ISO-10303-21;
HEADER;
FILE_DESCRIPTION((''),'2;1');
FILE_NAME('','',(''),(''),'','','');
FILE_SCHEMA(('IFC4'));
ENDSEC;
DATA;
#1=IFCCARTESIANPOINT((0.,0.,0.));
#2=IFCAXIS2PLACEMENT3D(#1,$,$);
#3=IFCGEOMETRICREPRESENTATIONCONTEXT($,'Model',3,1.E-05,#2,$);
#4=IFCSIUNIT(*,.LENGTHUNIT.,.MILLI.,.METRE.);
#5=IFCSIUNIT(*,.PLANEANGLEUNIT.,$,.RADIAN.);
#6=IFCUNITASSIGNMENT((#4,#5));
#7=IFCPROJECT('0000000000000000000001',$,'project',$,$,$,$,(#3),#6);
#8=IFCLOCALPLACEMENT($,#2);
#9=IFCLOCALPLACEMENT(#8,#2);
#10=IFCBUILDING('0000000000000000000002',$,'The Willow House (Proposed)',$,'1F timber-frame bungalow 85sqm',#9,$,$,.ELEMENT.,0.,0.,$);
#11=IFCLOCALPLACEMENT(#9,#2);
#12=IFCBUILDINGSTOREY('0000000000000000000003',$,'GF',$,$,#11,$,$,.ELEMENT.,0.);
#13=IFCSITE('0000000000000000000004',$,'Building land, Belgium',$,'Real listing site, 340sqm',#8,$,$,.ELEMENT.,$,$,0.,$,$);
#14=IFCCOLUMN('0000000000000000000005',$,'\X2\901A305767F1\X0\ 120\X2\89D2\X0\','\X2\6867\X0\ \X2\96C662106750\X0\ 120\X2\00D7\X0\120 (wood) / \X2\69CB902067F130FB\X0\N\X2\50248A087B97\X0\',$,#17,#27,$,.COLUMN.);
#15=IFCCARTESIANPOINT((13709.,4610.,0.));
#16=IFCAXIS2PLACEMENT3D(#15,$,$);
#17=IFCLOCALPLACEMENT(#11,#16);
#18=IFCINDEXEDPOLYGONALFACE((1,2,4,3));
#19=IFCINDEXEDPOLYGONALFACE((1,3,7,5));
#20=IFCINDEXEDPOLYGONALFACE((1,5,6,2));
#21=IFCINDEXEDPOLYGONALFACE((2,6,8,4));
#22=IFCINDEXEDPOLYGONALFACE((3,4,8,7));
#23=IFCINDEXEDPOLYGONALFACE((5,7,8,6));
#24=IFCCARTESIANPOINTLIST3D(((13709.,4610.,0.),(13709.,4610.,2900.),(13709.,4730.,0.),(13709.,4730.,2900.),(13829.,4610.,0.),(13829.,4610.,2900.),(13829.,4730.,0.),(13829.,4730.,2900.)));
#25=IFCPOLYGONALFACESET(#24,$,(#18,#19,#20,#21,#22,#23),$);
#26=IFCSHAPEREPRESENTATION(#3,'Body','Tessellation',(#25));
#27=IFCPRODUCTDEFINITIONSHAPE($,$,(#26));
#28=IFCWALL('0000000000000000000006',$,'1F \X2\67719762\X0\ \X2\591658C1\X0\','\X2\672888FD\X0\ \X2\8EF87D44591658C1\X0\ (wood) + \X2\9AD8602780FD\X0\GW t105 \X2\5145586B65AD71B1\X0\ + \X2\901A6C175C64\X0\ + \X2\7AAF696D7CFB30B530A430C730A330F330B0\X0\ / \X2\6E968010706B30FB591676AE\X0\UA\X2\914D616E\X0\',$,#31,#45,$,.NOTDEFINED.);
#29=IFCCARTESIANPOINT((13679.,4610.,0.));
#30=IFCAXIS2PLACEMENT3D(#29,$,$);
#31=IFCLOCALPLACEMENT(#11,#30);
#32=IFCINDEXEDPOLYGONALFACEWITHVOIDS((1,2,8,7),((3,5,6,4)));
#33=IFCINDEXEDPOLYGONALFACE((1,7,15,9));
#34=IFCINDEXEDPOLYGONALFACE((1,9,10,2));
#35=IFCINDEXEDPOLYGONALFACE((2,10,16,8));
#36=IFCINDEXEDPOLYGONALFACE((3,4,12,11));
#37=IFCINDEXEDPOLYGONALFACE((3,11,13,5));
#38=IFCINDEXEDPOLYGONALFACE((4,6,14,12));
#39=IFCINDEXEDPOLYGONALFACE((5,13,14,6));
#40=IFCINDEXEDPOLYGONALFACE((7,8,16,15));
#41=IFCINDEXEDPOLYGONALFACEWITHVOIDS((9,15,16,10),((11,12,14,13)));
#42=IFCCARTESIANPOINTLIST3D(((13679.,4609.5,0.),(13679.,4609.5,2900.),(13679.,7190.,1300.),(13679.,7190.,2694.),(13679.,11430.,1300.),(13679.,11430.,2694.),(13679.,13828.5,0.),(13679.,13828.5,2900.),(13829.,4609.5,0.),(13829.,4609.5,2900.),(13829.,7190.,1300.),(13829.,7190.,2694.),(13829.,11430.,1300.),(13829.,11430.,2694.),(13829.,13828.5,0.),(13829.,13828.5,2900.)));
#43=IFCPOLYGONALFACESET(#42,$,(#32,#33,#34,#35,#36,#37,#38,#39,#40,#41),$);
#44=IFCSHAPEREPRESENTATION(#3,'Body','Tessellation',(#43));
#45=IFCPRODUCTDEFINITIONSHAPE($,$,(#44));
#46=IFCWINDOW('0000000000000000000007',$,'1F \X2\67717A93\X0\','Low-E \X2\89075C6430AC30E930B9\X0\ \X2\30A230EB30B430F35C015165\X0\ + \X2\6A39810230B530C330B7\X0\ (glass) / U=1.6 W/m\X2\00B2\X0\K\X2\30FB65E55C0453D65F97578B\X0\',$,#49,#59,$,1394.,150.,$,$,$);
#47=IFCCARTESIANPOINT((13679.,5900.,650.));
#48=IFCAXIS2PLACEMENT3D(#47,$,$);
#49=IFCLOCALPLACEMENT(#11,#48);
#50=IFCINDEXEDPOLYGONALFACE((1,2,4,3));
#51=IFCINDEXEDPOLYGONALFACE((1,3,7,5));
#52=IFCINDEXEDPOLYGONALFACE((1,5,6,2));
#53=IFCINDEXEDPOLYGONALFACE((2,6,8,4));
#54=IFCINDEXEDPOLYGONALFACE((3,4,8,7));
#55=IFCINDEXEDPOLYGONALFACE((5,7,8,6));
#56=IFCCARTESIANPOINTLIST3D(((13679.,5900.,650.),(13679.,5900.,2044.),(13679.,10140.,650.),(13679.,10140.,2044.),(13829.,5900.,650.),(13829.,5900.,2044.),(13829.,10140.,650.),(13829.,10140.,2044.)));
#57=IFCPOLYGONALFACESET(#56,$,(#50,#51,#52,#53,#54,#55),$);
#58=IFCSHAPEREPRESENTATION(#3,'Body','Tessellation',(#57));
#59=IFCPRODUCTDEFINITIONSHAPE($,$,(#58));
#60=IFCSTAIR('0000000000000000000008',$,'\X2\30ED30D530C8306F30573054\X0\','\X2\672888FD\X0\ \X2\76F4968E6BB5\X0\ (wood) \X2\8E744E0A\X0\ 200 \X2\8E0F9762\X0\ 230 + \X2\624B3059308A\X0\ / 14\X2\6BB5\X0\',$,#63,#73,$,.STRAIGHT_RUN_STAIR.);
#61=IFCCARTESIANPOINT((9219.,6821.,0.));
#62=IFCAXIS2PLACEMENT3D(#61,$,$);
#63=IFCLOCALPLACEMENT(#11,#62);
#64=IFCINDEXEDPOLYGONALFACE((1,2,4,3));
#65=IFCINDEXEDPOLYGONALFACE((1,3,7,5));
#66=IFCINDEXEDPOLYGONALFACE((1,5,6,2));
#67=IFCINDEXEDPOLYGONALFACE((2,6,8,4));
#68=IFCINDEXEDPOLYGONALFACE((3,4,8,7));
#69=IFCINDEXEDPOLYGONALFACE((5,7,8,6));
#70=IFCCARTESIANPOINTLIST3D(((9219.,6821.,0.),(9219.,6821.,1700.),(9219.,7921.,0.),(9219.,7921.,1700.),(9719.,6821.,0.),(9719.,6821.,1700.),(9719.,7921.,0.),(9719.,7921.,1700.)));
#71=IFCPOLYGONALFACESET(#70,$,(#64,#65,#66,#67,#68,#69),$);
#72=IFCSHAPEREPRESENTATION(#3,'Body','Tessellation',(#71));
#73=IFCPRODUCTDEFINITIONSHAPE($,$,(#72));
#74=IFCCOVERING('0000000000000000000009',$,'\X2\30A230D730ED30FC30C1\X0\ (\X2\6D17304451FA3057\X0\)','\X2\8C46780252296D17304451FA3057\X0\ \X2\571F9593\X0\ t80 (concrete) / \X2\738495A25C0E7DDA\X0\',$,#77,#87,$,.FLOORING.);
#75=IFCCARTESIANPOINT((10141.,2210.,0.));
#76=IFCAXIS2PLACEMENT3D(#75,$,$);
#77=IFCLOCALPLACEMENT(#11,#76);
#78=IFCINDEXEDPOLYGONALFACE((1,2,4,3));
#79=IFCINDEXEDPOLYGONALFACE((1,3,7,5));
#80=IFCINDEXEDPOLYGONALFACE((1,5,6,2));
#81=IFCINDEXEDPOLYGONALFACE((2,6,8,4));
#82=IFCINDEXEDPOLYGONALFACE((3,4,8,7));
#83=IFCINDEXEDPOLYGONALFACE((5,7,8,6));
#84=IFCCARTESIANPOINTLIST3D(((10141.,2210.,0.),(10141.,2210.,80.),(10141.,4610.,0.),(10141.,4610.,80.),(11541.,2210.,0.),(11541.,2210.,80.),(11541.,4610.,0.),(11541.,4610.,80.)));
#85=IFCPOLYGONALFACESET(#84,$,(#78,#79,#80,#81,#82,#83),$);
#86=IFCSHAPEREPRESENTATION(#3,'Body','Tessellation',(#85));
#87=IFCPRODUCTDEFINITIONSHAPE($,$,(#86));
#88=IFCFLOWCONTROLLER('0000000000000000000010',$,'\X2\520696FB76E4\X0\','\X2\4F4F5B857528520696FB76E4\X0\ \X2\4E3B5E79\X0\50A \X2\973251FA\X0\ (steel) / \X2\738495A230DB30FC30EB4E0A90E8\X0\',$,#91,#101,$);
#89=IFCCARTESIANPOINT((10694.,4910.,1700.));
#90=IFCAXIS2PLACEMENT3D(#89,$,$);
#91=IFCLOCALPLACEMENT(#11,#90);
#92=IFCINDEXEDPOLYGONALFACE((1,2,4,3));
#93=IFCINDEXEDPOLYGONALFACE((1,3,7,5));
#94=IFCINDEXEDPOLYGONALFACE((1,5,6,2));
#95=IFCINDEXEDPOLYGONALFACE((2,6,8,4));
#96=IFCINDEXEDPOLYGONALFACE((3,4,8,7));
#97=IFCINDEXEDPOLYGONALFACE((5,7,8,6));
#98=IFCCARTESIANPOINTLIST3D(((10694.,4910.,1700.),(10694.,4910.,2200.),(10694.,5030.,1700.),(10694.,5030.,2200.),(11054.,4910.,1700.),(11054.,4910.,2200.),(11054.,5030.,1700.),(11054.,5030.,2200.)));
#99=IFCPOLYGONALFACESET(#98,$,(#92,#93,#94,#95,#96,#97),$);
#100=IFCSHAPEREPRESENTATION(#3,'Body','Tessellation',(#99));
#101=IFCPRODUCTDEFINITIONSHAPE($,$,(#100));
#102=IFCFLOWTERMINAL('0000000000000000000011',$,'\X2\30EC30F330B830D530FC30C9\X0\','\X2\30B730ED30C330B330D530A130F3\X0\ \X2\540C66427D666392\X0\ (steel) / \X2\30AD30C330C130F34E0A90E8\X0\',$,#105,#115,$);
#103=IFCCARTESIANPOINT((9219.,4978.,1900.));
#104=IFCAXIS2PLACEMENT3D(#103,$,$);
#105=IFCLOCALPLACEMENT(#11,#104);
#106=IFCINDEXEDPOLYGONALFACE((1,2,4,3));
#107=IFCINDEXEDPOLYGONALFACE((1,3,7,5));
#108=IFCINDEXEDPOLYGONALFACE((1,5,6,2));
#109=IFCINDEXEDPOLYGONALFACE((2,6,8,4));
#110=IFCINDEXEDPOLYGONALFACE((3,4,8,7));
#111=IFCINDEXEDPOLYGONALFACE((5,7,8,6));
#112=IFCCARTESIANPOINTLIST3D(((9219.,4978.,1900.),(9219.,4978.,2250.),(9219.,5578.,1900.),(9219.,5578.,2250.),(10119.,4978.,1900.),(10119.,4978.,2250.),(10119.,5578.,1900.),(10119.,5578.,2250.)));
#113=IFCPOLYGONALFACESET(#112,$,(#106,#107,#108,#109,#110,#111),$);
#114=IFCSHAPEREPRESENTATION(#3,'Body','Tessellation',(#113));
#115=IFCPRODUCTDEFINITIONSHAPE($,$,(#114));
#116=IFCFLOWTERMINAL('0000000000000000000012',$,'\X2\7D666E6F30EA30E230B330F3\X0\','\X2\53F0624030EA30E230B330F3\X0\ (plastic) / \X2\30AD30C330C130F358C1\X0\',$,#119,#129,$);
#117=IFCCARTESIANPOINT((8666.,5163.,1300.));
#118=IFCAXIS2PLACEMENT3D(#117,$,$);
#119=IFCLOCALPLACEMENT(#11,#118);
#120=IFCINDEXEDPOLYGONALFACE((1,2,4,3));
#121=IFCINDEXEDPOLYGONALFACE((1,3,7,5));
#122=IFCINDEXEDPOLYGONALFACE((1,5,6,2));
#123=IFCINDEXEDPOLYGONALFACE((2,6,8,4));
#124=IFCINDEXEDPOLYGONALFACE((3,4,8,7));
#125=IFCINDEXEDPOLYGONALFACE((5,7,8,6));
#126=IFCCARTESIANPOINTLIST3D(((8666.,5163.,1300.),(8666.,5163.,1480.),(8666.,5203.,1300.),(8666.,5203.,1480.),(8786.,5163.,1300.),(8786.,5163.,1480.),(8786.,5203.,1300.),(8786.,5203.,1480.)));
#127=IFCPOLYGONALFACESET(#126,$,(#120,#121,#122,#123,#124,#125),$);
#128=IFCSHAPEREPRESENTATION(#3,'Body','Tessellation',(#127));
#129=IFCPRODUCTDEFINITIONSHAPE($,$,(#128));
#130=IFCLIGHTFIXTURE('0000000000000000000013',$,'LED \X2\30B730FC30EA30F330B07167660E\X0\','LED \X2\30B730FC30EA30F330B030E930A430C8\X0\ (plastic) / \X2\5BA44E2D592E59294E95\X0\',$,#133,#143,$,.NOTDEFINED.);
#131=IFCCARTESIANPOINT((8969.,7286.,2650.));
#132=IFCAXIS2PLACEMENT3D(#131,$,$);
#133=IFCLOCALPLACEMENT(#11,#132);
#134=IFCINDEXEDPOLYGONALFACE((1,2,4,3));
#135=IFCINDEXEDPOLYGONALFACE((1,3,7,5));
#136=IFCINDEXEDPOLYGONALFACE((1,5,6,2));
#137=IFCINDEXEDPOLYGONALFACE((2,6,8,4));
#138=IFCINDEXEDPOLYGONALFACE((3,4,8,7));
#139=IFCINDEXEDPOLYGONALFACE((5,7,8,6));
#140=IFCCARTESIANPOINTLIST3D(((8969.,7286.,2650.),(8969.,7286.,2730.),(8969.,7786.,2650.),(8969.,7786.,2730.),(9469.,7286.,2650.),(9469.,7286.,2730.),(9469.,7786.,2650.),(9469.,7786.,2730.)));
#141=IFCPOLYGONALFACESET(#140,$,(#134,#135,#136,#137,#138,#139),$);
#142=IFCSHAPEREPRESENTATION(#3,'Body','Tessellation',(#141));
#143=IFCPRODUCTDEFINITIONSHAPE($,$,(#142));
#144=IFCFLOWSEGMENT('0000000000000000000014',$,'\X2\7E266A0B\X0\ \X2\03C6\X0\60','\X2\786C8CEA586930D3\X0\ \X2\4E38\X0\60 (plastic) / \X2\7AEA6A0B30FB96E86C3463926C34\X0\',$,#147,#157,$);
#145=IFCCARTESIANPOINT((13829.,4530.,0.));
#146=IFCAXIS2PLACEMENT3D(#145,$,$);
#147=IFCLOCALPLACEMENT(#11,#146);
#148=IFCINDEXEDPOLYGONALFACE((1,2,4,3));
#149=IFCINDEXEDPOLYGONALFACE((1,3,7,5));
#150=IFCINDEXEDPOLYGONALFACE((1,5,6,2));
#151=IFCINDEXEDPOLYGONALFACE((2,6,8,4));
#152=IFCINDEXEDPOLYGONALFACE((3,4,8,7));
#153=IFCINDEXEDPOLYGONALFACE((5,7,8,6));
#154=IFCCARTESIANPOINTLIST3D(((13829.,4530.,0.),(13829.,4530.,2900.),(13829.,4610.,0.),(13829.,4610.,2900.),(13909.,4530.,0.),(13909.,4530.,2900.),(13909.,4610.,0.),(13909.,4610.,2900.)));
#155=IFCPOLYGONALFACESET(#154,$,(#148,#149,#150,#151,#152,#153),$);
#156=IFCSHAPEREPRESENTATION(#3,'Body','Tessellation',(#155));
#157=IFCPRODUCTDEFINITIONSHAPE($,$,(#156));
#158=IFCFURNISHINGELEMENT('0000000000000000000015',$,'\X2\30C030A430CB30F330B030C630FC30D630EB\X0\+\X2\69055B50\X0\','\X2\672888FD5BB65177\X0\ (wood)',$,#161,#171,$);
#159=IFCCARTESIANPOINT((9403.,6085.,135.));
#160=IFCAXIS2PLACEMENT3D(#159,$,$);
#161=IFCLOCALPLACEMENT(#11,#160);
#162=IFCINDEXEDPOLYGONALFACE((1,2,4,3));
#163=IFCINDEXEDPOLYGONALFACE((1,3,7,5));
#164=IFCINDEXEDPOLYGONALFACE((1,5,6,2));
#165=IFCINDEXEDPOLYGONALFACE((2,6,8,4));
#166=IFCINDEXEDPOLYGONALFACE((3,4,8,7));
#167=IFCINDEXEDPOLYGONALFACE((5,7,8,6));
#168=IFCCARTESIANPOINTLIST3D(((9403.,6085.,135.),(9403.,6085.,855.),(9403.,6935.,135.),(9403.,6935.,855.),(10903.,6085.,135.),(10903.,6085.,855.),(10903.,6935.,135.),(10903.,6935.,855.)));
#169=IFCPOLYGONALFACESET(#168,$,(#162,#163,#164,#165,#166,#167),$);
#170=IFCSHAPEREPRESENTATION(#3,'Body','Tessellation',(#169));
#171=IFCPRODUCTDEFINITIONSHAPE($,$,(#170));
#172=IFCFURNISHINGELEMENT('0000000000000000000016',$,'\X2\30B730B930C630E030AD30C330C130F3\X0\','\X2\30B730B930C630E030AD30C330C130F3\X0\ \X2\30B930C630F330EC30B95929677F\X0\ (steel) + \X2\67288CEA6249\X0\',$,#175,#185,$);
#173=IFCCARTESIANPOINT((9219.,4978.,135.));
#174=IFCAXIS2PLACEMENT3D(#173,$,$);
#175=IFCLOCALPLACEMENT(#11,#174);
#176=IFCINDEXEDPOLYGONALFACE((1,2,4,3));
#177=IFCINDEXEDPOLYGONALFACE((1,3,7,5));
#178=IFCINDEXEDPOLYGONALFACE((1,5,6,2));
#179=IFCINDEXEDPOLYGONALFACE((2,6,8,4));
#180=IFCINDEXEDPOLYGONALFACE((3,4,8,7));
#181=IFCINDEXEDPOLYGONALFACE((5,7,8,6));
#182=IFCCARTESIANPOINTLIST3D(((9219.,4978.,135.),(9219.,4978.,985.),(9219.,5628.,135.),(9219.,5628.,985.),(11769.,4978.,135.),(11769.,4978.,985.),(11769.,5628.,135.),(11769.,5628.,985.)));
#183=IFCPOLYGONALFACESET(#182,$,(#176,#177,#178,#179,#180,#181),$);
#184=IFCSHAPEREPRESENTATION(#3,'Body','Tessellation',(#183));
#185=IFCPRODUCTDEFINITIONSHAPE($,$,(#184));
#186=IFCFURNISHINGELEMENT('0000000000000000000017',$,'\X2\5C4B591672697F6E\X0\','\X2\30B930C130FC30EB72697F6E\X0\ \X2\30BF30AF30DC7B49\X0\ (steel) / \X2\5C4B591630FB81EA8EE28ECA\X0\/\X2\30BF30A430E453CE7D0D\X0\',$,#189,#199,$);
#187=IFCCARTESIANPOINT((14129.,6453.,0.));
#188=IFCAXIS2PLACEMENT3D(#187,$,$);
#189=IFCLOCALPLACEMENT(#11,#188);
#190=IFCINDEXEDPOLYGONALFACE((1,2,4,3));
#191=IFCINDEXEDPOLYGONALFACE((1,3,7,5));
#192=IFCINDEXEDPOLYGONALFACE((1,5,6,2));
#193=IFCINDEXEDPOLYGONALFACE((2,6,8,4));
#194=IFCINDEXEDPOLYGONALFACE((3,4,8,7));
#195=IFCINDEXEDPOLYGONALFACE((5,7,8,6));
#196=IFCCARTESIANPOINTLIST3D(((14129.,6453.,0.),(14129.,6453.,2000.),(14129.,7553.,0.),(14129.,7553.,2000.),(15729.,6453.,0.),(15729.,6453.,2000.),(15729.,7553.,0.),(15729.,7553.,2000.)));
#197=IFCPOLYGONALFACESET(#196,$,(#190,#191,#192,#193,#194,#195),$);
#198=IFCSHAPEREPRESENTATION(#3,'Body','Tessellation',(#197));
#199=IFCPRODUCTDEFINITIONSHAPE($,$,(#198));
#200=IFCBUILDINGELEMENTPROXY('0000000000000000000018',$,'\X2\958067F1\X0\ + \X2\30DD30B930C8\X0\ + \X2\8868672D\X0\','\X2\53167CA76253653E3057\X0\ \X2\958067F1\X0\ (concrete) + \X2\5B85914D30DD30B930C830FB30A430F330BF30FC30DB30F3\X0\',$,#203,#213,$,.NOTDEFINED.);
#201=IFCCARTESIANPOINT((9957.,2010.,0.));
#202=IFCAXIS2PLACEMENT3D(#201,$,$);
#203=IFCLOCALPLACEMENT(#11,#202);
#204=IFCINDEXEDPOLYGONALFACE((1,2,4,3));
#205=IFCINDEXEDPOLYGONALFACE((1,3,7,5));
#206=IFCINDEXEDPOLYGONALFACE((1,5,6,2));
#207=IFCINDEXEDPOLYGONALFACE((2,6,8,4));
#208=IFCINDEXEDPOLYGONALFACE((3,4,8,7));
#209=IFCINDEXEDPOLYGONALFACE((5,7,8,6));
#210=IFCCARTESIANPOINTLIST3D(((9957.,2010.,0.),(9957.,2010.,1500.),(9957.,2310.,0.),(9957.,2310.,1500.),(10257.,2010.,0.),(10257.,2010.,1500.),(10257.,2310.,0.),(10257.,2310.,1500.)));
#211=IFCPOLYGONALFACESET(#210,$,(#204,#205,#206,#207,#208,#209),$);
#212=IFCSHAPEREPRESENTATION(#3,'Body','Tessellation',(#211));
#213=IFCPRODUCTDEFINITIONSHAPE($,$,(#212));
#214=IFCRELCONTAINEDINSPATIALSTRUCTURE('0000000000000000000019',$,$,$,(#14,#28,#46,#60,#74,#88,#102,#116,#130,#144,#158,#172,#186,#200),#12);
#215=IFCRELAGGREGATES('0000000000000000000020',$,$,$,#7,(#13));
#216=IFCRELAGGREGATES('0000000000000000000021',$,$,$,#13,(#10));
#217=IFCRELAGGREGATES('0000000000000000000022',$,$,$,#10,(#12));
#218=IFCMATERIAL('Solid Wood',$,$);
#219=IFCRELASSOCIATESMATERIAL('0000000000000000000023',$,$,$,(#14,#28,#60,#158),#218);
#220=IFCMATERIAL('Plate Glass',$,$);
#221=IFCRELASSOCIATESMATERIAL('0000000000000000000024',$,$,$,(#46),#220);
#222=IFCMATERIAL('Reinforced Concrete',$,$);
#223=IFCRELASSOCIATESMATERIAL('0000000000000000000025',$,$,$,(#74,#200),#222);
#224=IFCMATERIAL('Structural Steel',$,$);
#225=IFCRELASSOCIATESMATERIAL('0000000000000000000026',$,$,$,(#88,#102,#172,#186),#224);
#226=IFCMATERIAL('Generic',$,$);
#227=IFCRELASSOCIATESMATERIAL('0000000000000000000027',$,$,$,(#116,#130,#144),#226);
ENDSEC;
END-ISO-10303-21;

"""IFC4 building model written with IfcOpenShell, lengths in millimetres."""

from ifc_helpers import new_model, si_unit, frame, frame_2d, origin, place, context, project, spatial, rectangle, extrude, material, element, fill, save


model = new_model("IFC4")

# Units and contexts
model_context = context("Model", 3, precision=1e-05, world=origin())
ifc_project = project(units=[si_unit("LENGTHUNIT", "METRE", prefix="MILLI"), si_unit("PLANEANGLEUNIT", "RADIAN")], contexts=[model_context])

# Site, building, storey
site_placement = place(None, origin())
site = spatial("IfcSite", under=ifc_project, at=site_placement, Name="Building land, Belgium", ObjectType="Real listing site, 340sqm", CompositionType="ELEMENT", RefElevation=0.0)
building_placement = place(site_placement, origin())
building = spatial("IfcBuilding", under=site, at=building_placement, Name="The Willow House (Proposed)", ObjectType="1F timber-frame bungalow 85sqm", CompositionType="ELEMENT", ElevationOfRefHeight=0.0, ElevationOfTerrain=0.0)
storey_placement = place(building_placement, origin())
storey = spatial("IfcBuildingStorey", under=building, at=storey_placement, Name="GF", CompositionType="ELEMENT", Elevation=0.0)

# Column
ifc_material_1 = material(Name="Solid Wood")
column_1_placement = place(storey_placement, frame((13709.0, 4610.0, 0.0)))
element("IfcColumn", 1, at=column_1_placement, inside=storey, material=ifc_material_1, Name="通し柱 120角", Description="桧 集成材 120×120 (wood) / 構造柱・N値計算", PredefinedType="COLUMN", context=model_context, shape_type="SweptSolid", body=[
    extrude(rectangle(XDim=120.0, YDim=120.0, at=frame_2d((60.0, 60.0))), frame((13709.0, 4610.0, 0.0)), (0.0, 0.0, 1.0), 2900.0),
])

# Wall, opening, window
wall_1_placement = place(storey_placement, frame((13679.0, 4610.0, 0.0)))
wall_1 = element("IfcWall", 2, at=wall_1_placement, inside=storey, material=ifc_material_1, Name="1F 東面 外壁", Description="木製 軸組外壁 (wood) + 高性能GW t105 充填断熱 + 通気層 + 窯業系サイディング / 準耐火・外皮UA配慮", PredefinedType="NOTDEFINED", context=model_context, shape_type="SweptSolid", body=[
    extrude(rectangle(XDim=150.0, YDim=9219.0, at=frame_2d((75.0, 4609.0))), frame((13679.0, 4610.0, 0.0)), (0.0, 0.0, 1.0), 2900.0),
])
opening_placement = place(storey_placement, frame((13679.0, 5900.0, 650.0)))
opening = element("IfcOpeningElement", 3, at=opening_placement, cuts=wall_1, PredefinedType="NOTDEFINED", context=model_context, shape_type="SweptSolid", body=[
    extrude(rectangle(XDim=150.0, YDim=4240.0, at=frame_2d((75.0, 2120.0))), frame((13679.0, 5900.0, 650.0)), (0.0, 0.0, 1.0), 1394.0),
])
ifc_material_2 = material(Name="Plate Glass")
window_placement = place(storey_placement, frame((13679.0, 5900.0, 650.0)))
window = element("IfcWindow", 4, at=window_placement, inside=storey, material=ifc_material_2, Name="1F 東窓", Description="Low-E 複層ガラス アルゴン封入 + 樹脂サッシ (glass) / U=1.6 W/m²K・日射取得型", OverallHeight=1394.0, OverallWidth=150.0, context=model_context, shape_type="SweptSolid", body=[
    extrude(rectangle(XDim=150.0, YDim=4240.0, at=frame_2d((75.0, 2120.0))), frame((13679.0, 5900.0, 650.0)), (0.0, 0.0, 1.0), 1394.0),
])
fill(opening, window)

# Stair
stair_placement = place(storey_placement, frame((9219.0, 6821.0, 0.0)))
element("IfcStair", 5, at=stair_placement, inside=storey, material=ifc_material_1, Name="ロフトはしご", Description="木製 直階段 (wood) 蹴上 200 踏面 230 + 手すり / 14段", PredefinedType="STRAIGHT_RUN_STAIR", context=model_context, shape_type="SweptSolid", body=[
    extrude(rectangle(XDim=500.0, YDim=1100.0, at=frame_2d((250.0, 550.0))), frame((9219.0, 6821.0, 0.0)), (0.0, 0.0, 1.0), 1700.0),
])

# Covering
ifc_material_3 = material(Name="Reinforced Concrete")
covering_placement = place(storey_placement, frame((10141.0, 2210.0, 0.0)))
element("IfcCovering", 6, at=covering_placement, inside=storey, material=ifc_material_3, Name="アプローチ (洗い出し)", Description="豆砂利洗い出し 土間 t80 (concrete) / 玄関導線", PredefinedType="FLOORING", context=model_context, shape_type="SweptSolid", body=[
    extrude(rectangle(XDim=1400.0, YDim=2400.0, at=frame_2d((700.0, 1200.0))), frame((10141.0, 2210.0, 0.0)), (0.0, 0.0, 1.0), 80.0),
])

# Flow controller
ifc_material_4 = material(Name="Structural Steel")
flow_controller_placement = place(storey_placement, frame((10694.0, 4910.0, 1700.0)))
element("IfcFlowController", 7, at=flow_controller_placement, inside=storey, material=ifc_material_4, Name="分電盤", Description="住宅用分電盤 主幹50A 露出 (steel) / 玄関ホール上部", context=model_context, shape_type="SweptSolid", body=[
    extrude(rectangle(XDim=360.0, YDim=120.0, at=frame_2d((180.0, 60.0))), frame((10694.0, 4910.0, 1700.0)), (0.0, 0.0, 1.0), 500.0),
])

# Flow terminals
flow_terminal_1_placement = place(storey_placement, frame((9219.0, 4978.0, 1900.0)))
element("IfcFlowTerminal", 8, at=flow_terminal_1_placement, inside=storey, material=ifc_material_4, Name="レンジフード", Description="シロッコファン 同時給排 (steel) / キッチン上部", context=model_context, shape_type="SweptSolid", body=[
    extrude(rectangle(XDim=900.0, YDim=600.0, at=frame_2d((450.0, 300.0))), frame((9219.0, 4978.0, 1900.0)), (0.0, 0.0, 1.0), 350.0),
])
ifc_material_5 = material(Name="Generic")
flow_terminal_2_placement = place(storey_placement, frame((8666.0, 5163.0, 1300.0)))
element("IfcFlowTerminal", 9, at=flow_terminal_2_placement, inside=storey, material=ifc_material_5, Name="給湯リモコン", Description="台所リモコン (plastic) / キッチン壁", context=model_context, shape_type="SweptSolid", body=[
    extrude(rectangle(XDim=120.0, YDim=40.0, at=frame_2d((60.0, 20.0))), frame((8666.0, 5163.0, 1300.0)), (0.0, 0.0, 1.0), 180.0),
])

# Light fixture
light_fixture_placement = place(storey_placement, frame((8969.0, 7286.0, 2650.0)))
element("IfcLightFixture", 10, at=light_fixture_placement, inside=storey, material=ifc_material_5, Name="LED シーリング照明", Description="LED シーリングライト (plastic) / 室中央天井", PredefinedType="NOTDEFINED", context=model_context, shape_type="SweptSolid", body=[
    extrude(rectangle(XDim=500.0, YDim=500.0, at=frame_2d((250.0, 250.0))), frame((8969.0, 7286.0, 2650.0)), (0.0, 0.0, 1.0), 80.0),
])

# Flow segment
flow_segment_placement = place(storey_placement, frame((13829.0, 4530.0, 0.0)))
element("IfcFlowSegment", 11, at=flow_segment_placement, inside=storey, material=ifc_material_5, Name="縦樋 φ60", Description="硬質塩ビ 丸60 (plastic) / 竪樋・雨水排水", context=model_context, shape_type="SweptSolid", body=[
    extrude(rectangle(XDim=80.0, YDim=80.0, at=frame_2d((40.0, 40.0))), frame((13829.0, 4530.0, 0.0)), (0.0, 0.0, 1.0), 2900.0),
])

# Furnishing elements
furnishing_1_placement = place(storey_placement, frame((9403.0, 6085.0, 135.0)))
element("IfcFurnishingElement", 12, at=furnishing_1_placement, inside=storey, material=ifc_material_1, Name="ダイニングテーブル+椅子", Description="木製家具 (wood)", context=model_context, shape_type="SweptSolid", body=[
    extrude(rectangle(XDim=1500.0, YDim=850.0, at=frame_2d((750.0, 425.0))), frame((9403.0, 6085.0, 135.0)), (0.0, 0.0, 1.0), 720.0),
])
furnishing_2_placement = place(storey_placement, frame((9219.0, 4978.0, 135.0)))
element("IfcFurnishingElement", 13, at=furnishing_2_placement, inside=storey, material=ifc_material_4, Name="システムキッチン", Description="システムキッチン ステンレス天板 (steel) + 木質扉", context=model_context, shape_type="SweptSolid", body=[
    extrude(rectangle(XDim=2550.0, YDim=650.0, at=frame_2d((1275.0, 325.0))), frame((9219.0, 4978.0, 135.0)), (0.0, 0.0, 1.0), 850.0),
])
furnishing_3_placement = place(storey_placement, frame((14129.0, 6453.0, 0.0)))
element("IfcFurnishingElement", 14, at=furnishing_3_placement, inside=storey, material=ifc_material_4, Name="屋外物置", Description="スチール物置 タクボ等 (steel) / 屋外・自転車/タイヤ収納", context=model_context, shape_type="SweptSolid", body=[
    extrude(rectangle(XDim=1600.0, YDim=1100.0, at=frame_2d((800.0, 550.0))), frame((14129.0, 6453.0, 0.0)), (0.0, 0.0, 1.0), 2000.0),
])

# Building element proxy
proxy_placement = place(storey_placement, frame((9957.0, 2010.0, 0.0)))
element("IfcBuildingElementProxy", 15, at=proxy_placement, inside=storey, material=ifc_material_3, Name="門柱 + ポスト + 表札", Description="化粧打放し 門柱 (concrete) + 宅配ポスト・インターホン", PredefinedType="NOTDEFINED", context=model_context, shape_type="SweptSolid", body=[
    extrude(rectangle(XDim=300.0, YDim=300.0, at=frame_2d((150.0, 150.0))), frame((9957.0, 2010.0, 0.0)), (0.0, 0.0, 1.0), 1500.0),
])

save(model, "model.ifc")
